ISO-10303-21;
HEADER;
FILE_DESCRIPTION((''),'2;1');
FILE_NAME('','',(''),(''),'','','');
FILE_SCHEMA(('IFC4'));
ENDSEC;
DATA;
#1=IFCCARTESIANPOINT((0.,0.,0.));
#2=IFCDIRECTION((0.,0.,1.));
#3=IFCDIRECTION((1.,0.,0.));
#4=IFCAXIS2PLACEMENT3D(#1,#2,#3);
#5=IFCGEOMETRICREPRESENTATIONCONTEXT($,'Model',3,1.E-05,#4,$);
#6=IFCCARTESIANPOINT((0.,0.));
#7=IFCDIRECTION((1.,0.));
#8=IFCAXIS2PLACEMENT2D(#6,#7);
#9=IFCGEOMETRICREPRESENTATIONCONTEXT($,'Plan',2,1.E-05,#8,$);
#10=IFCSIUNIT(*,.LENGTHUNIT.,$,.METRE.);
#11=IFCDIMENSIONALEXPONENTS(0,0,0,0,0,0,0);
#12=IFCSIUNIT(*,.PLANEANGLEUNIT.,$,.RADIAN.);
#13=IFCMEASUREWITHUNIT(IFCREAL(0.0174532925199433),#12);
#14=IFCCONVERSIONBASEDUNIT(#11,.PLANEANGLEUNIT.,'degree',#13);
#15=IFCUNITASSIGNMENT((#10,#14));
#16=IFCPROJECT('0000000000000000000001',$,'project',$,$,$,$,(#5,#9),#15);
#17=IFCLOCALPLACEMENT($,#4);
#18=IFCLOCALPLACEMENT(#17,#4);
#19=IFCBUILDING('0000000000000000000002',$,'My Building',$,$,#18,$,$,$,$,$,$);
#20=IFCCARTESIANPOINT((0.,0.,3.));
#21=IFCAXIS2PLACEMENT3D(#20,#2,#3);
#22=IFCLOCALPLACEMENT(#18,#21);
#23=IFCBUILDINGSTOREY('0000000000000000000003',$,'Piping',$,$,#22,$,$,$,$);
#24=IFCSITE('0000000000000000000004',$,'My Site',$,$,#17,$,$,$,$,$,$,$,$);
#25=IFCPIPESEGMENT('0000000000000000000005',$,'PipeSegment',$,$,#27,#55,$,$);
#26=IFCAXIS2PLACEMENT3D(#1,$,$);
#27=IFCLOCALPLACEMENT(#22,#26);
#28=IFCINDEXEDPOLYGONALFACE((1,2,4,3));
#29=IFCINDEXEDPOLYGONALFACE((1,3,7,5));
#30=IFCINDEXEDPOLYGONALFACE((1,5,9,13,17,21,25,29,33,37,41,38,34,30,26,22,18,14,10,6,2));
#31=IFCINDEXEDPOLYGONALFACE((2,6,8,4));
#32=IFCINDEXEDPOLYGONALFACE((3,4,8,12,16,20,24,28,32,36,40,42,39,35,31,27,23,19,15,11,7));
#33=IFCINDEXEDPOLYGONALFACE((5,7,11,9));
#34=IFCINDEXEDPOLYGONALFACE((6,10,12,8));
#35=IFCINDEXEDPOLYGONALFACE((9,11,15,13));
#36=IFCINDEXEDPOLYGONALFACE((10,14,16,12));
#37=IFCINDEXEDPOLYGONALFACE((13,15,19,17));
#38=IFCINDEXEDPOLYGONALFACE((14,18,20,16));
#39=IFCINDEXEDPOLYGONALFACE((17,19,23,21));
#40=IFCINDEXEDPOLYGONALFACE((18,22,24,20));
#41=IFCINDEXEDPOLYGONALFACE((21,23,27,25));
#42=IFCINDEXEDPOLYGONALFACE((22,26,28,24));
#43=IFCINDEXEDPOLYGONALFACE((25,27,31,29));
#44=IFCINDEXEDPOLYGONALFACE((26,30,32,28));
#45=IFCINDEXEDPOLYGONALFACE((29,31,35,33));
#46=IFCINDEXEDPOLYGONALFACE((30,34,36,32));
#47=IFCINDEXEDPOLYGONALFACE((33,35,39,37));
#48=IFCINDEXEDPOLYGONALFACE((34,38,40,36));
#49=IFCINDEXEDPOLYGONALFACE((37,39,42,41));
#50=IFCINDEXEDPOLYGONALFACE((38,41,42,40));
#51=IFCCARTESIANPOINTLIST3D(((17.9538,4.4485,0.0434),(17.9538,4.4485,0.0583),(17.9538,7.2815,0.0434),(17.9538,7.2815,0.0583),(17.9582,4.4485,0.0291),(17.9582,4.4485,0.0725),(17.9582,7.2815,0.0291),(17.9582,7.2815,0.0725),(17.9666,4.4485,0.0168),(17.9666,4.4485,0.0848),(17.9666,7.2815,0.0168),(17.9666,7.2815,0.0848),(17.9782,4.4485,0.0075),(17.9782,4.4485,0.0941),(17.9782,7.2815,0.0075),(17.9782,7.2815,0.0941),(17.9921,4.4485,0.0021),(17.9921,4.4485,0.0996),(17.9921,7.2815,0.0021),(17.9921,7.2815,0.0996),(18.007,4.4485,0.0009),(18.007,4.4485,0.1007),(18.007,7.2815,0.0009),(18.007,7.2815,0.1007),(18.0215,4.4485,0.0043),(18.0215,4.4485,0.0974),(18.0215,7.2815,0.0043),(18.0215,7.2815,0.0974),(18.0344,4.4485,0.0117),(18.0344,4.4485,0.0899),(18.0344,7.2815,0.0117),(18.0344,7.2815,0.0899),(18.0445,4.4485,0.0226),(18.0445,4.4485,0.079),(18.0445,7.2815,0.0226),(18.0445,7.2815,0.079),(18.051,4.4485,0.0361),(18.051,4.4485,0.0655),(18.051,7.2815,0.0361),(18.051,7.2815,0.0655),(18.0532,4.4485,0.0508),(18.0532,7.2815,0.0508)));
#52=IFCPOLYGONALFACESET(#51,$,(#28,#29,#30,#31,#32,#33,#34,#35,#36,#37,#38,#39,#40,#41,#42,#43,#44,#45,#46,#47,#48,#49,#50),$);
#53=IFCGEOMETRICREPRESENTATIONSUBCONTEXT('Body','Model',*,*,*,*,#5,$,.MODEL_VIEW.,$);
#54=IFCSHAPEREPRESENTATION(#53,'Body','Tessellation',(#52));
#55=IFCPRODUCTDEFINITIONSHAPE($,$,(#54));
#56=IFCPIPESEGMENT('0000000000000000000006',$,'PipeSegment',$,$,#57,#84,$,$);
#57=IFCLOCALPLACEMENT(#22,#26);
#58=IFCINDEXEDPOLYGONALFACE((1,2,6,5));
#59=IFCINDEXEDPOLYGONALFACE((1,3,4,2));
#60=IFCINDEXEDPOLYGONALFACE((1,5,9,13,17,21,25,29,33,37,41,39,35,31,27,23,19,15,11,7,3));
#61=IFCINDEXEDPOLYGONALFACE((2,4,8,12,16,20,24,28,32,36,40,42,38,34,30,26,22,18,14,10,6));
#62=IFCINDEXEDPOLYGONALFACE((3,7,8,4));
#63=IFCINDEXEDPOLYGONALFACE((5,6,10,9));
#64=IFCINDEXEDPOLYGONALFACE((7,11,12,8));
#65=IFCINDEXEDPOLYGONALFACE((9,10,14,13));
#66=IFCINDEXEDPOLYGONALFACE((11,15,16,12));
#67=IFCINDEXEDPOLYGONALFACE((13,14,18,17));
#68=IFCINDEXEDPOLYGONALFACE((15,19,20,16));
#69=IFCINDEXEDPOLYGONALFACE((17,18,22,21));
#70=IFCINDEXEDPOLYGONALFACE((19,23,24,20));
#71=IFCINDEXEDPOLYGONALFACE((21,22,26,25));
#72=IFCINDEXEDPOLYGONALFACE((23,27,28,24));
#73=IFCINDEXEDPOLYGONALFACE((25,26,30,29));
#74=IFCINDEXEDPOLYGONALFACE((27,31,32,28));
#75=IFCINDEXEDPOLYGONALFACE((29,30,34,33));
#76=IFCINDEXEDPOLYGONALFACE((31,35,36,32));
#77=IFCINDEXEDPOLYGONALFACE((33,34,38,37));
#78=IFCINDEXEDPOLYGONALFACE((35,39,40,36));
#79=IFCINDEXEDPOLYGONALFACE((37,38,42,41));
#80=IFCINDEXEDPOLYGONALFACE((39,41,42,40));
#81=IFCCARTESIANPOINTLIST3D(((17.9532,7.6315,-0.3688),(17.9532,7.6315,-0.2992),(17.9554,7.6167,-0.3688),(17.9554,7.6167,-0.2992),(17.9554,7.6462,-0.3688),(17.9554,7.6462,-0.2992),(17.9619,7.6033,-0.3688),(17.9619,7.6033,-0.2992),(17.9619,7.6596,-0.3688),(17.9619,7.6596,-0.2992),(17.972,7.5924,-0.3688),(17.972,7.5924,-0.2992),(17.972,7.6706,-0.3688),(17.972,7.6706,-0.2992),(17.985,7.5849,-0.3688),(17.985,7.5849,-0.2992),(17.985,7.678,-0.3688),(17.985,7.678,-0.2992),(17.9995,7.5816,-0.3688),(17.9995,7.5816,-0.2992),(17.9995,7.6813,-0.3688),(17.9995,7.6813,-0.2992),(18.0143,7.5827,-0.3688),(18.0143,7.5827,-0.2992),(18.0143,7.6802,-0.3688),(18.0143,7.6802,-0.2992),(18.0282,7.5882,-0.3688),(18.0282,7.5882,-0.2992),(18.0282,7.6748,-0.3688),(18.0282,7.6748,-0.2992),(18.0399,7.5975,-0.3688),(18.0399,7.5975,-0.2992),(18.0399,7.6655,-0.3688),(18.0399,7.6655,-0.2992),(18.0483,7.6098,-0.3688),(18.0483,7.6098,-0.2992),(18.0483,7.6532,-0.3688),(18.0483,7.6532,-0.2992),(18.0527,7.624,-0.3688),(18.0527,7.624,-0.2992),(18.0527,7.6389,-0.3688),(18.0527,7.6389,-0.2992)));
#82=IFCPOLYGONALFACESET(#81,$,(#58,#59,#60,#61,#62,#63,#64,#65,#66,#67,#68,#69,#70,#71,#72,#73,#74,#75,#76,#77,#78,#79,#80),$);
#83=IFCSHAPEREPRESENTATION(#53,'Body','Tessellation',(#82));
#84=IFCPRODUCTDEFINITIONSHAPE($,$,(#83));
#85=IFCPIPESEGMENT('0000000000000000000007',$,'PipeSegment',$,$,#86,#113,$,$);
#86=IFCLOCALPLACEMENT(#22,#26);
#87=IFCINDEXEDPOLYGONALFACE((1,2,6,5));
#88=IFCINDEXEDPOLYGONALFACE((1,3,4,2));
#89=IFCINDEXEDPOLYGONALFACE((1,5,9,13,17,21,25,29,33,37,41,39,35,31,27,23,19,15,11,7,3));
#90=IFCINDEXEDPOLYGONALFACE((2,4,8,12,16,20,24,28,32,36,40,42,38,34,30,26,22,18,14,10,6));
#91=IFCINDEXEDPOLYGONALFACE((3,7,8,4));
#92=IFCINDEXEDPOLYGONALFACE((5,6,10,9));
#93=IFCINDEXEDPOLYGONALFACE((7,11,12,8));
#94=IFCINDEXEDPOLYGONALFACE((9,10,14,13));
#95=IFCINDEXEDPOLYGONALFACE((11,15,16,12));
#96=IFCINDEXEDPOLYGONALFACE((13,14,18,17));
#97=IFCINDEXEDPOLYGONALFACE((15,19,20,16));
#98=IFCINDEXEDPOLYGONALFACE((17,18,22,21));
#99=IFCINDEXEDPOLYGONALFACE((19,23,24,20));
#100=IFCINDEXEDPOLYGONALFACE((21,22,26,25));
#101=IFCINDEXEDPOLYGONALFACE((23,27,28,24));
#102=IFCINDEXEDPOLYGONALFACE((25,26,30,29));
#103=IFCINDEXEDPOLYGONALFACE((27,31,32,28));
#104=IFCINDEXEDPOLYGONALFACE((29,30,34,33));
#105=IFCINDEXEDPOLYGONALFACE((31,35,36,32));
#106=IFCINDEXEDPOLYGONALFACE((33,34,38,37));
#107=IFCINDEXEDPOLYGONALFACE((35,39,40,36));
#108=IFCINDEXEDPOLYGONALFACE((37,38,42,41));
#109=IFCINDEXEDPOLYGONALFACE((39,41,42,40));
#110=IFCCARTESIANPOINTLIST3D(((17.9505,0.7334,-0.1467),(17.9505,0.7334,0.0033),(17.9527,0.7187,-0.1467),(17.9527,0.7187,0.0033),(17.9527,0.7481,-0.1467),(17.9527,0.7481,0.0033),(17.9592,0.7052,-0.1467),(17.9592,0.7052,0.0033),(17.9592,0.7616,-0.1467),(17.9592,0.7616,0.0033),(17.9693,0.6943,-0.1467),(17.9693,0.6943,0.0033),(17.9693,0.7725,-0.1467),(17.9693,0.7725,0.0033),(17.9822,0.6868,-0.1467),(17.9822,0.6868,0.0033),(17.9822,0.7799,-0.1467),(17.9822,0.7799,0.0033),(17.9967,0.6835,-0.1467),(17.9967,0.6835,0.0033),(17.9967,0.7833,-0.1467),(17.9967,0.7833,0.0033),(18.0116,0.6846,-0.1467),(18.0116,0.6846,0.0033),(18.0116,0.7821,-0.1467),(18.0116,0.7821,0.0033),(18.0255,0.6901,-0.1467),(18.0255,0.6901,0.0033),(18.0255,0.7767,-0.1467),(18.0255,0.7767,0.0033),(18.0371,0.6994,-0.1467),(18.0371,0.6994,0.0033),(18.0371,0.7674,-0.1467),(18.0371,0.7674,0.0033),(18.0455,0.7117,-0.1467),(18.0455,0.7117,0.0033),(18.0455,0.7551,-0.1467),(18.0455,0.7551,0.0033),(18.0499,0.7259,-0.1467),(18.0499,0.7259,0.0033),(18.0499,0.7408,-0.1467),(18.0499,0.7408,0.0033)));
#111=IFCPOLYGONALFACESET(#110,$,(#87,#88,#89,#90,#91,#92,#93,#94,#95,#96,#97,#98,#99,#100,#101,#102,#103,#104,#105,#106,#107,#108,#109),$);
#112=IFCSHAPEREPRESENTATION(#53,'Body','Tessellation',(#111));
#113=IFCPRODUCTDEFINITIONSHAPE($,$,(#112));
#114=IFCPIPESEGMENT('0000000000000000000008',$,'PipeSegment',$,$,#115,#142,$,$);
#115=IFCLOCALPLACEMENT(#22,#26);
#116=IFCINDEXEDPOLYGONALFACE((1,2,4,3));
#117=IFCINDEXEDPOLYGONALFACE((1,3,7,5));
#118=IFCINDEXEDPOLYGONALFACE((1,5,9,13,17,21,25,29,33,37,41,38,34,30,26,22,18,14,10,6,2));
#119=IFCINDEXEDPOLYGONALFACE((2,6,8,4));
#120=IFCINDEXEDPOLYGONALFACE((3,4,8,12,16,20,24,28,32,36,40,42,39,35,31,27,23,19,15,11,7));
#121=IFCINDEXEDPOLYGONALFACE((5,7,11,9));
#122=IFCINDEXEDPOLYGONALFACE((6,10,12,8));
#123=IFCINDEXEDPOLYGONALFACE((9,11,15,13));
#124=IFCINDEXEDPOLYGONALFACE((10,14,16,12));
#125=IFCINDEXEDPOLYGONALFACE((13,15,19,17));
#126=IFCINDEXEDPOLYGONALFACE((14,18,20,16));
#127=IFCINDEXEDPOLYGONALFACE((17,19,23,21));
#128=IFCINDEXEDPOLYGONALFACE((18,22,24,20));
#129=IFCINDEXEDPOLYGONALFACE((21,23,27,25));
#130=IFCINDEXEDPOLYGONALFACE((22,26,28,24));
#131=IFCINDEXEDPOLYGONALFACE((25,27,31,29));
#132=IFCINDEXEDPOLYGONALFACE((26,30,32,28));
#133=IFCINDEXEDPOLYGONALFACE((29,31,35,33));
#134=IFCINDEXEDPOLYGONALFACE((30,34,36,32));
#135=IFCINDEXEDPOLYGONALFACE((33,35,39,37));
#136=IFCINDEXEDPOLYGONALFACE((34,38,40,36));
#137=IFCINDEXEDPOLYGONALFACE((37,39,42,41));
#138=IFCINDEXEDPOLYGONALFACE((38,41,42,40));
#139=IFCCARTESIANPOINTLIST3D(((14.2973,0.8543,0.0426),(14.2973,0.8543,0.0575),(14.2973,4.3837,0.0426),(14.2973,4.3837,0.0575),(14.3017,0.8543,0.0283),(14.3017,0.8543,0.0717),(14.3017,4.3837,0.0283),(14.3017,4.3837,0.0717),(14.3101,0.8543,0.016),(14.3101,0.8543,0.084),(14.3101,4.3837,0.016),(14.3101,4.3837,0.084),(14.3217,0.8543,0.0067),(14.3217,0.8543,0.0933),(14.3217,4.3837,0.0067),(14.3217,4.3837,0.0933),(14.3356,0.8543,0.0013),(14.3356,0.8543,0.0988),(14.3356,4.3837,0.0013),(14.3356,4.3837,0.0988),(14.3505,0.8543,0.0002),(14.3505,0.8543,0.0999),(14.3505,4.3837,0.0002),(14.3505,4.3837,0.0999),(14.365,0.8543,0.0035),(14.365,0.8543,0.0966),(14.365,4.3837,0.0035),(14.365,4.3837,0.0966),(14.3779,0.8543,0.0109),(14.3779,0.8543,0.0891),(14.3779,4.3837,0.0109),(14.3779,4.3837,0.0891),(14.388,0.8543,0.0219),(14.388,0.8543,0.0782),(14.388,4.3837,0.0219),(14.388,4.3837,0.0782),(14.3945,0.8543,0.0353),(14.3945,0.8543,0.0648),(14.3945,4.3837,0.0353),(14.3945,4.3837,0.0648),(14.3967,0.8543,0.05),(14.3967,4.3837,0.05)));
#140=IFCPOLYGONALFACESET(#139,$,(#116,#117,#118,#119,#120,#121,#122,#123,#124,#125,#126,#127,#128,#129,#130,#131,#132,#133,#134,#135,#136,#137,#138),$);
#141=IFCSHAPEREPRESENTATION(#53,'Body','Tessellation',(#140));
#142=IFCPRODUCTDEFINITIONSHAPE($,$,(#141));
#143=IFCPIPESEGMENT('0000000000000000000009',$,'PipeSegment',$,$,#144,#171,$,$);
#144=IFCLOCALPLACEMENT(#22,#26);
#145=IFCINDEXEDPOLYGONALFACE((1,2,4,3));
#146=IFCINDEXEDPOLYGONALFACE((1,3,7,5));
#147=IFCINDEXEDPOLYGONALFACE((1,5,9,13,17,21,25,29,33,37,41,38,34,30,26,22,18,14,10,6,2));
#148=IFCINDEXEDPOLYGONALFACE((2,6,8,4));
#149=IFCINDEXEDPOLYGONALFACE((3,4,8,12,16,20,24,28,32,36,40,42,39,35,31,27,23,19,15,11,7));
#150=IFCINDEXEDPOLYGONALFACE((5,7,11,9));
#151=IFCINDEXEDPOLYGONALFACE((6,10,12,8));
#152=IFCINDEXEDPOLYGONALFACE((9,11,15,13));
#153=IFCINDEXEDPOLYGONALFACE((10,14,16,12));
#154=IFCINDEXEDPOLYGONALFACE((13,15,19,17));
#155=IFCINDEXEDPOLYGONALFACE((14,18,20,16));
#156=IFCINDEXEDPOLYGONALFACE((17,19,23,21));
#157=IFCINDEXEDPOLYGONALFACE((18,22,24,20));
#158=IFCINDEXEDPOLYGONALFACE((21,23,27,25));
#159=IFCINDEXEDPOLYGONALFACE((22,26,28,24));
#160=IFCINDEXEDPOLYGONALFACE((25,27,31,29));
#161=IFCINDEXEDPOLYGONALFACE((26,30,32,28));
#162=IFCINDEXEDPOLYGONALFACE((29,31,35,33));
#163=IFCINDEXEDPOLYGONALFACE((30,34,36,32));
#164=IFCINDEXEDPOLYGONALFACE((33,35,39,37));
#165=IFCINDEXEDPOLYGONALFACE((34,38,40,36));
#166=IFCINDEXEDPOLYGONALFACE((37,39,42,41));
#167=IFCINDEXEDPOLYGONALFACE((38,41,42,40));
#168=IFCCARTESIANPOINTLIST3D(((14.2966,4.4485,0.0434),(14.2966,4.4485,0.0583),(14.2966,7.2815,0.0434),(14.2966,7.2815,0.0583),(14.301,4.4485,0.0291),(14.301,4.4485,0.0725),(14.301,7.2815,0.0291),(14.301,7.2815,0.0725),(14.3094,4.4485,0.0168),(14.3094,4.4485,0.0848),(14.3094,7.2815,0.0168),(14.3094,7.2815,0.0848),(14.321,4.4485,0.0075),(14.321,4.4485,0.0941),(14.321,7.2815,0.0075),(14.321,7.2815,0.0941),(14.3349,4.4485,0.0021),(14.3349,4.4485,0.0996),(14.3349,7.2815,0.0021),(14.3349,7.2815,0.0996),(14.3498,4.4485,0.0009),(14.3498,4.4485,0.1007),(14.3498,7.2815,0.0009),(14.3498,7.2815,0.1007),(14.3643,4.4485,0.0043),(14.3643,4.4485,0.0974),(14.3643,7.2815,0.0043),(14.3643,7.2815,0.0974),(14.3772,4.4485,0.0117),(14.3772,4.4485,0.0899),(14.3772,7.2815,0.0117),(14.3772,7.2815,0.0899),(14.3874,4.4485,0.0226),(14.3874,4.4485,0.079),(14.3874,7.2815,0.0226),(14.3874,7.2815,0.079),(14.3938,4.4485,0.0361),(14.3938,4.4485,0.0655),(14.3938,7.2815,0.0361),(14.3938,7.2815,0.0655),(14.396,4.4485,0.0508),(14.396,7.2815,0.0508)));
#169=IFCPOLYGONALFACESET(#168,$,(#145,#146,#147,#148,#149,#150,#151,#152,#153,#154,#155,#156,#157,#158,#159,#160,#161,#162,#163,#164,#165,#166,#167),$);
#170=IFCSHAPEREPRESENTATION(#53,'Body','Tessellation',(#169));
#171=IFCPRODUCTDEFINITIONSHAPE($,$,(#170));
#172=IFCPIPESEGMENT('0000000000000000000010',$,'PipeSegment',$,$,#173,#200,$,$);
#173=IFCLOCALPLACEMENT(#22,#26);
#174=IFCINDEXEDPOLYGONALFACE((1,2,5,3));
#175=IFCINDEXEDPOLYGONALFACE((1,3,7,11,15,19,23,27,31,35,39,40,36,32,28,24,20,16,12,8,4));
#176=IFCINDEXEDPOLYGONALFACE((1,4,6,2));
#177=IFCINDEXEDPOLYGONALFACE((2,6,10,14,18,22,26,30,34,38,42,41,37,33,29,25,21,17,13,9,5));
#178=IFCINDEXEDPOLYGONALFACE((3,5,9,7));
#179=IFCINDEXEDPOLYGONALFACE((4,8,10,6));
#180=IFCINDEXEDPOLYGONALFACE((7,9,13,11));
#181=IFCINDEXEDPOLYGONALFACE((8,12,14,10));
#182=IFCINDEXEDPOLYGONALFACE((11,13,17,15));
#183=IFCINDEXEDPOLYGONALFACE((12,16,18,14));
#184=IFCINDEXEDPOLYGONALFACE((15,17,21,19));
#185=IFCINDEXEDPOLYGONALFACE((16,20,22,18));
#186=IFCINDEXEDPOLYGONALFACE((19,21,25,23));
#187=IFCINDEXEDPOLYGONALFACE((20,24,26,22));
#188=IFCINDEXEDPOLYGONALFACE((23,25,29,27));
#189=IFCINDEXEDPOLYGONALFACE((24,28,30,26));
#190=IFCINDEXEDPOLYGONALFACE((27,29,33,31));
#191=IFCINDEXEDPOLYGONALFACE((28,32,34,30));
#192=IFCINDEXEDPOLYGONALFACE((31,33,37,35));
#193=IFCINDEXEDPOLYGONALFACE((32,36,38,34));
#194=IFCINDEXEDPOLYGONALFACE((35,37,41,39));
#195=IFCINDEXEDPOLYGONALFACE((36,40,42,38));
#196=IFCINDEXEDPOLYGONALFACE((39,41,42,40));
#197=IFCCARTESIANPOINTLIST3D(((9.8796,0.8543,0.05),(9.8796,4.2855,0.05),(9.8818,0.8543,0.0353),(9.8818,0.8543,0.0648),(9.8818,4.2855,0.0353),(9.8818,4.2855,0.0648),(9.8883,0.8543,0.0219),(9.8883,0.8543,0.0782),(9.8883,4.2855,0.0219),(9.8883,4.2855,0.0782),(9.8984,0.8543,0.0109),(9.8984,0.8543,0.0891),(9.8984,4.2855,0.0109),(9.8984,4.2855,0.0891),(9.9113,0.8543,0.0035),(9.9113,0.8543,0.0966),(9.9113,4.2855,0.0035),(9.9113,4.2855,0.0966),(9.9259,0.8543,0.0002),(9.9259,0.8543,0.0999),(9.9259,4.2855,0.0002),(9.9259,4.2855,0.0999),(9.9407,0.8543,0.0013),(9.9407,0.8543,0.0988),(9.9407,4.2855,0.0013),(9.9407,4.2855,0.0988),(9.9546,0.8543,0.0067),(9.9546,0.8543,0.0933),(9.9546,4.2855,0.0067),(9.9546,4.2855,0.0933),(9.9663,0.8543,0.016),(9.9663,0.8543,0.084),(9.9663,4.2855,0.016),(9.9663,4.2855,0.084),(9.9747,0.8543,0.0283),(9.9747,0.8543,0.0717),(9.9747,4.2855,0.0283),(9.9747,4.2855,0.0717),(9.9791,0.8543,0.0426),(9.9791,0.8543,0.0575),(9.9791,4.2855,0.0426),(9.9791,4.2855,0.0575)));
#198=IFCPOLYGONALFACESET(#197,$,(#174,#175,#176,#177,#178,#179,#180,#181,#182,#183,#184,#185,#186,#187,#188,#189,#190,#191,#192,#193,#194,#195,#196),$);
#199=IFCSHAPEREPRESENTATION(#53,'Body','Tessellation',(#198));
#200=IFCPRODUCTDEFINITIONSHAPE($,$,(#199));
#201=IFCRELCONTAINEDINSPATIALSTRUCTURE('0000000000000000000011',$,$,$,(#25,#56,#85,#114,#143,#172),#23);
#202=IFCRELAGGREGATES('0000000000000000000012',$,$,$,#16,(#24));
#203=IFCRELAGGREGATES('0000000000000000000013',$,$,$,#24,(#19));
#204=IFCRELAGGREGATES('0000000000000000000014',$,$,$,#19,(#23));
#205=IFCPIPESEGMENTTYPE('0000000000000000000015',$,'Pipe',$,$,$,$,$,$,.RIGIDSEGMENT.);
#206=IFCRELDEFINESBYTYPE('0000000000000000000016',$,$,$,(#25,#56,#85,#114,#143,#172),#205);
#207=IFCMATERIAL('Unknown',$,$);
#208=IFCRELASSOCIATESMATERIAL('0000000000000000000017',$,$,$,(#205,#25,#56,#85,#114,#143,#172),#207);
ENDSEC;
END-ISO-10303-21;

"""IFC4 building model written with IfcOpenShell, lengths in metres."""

from ifc_helpers import new_model, entity, si_unit, converted_unit, frame, origin_with_axes, origin_2d_with_axis, place, context, subcontext, project, spatial, circle, extrude, material, material_profile, profile_set, profile_usage, type_object, element, save


model = new_model("IFC4")

# Units and contexts
model_context = context("Model", 3, precision=1e-05, world=origin_with_axes())
plan_context = context("Plan", 2, precision=1e-05, world=origin_2d_with_axis())
body_context = subcontext(model_context, "Body", "Model", "MODEL_VIEW")
ifc_project = project(units=[si_unit("LENGTHUNIT", "METRE"), converted_unit("PLANEANGLEUNIT", "degree", entity("IfcReal", 0.0174532925199433), si_unit("PLANEANGLEUNIT", "RADIAN"), dimensions=[0, 0, 0, 0, 0, 0, 0])], contexts=[model_context, plan_context])

# Site, building, storey
site_placement = place(None, origin_with_axes())
site = spatial("IfcSite", under=ifc_project, at=site_placement, Name="My Site")
building_placement = place(site_placement, origin_with_axes())
building = spatial("IfcBuilding", under=site, at=building_placement, Name="My Building")
storey_placement = place(building_placement, frame((0.0, 0.0, 3.0), z_axis=(0.0, 0.0, 1.0), x_axis=(1.0, 0.0, 0.0)))
storey = spatial("IfcBuildingStorey", under=building, at=storey_placement, Name="Piping")

# Pipe segments
ifc_material = material(Name="Unknown")
ifc_material_profile_1 = material_profile(ifc_material, circle(Radius=0.05))
ifc_profile_set_1 = profile_set([ifc_material_profile_1])
pipe_segment_type = type_object("IfcPipeSegmentType", Name="Pipe", PredefinedType="RIGIDSEGMENT", material=ifc_profile_set_1)
ifc_profile_usage_1 = profile_usage(ifc_profile_set_1, cardinal=5)
pipe_segment_1_placement = place(storey_placement, frame((18.0032, 4.4485, 0.0508), z_axis=(0.0, 1.0, 0.0), x_axis=(1.0, 0.0, 0.0)))
element("IfcPipeSegment", 1, at=pipe_segment_1_placement, inside=storey, type_object=pipe_segment_type, material=ifc_profile_usage_1, Name="PipeSegment", context=body_context, shape_type="SweptSolid", body=[
    extrude(circle(Radius=0.05), origin_with_axes(), (0.0, 0.0, 1.0), 2.833),
])
ifc_profile_usage_2 = profile_usage(ifc_profile_set_1, cardinal=16)
pipe_segment_2_placement = place(storey_placement, frame((18.0032, 7.6315, -0.2992), z_axis=(0.0, 0.0, -1.0), x_axis=(-1.0, 0.0, 0.0)))
element("IfcPipeSegment", 2, at=pipe_segment_2_placement, inside=storey, type_object=pipe_segment_type, material=ifc_profile_usage_2, Name="PipeSegment", context=body_context, shape_type="SweptSolid", body=[
    extrude(circle(Radius=0.05), origin_with_axes(), (0.0, 0.0, 1.0), 0.0696),
])
ifc_profile_usage_3 = profile_usage(ifc_profile_set_1, cardinal=16)
pipe_segment_3_placement = place(storey_placement, frame((18.0005, 0.7334, 0.0033), z_axis=(0.0, 0.0, -1.0), x_axis=(-1.0, 0.0, 0.0)))
element("IfcPipeSegment", 3, at=pipe_segment_3_placement, inside=storey, type_object=pipe_segment_type, material=ifc_profile_usage_3, Name="PipeSegment", context=body_context, shape_type="SweptSolid", body=[
    extrude(circle(Radius=0.05), origin_with_axes(), (0.0, 0.0, 1.0), 0.15),
])
ifc_profile_usage_4 = profile_usage(ifc_profile_set_1, cardinal=5)
pipe_segment_4_placement = place(storey_placement, frame((14.3467, 4.3837, 0.05), z_axis=(0.0, -1.0, 0.0), x_axis=(1.0, 0.0, 0.0)))
element("IfcPipeSegment", 4, at=pipe_segment_4_placement, inside=storey, type_object=pipe_segment_type, material=ifc_profile_usage_4, Name="PipeSegment", context=body_context, shape_type="SweptSolid", body=[
    extrude(circle(Radius=0.05), origin_with_axes(), (0.0, 0.0, 1.0), 3.5295),
])
ifc_profile_usage_5 = profile_usage(ifc_profile_set_1, cardinal=5)
pipe_segment_5_placement = place(storey_placement, frame((14.346, 4.4485, 0.0508), z_axis=(0.0, 1.0, 0.0), x_axis=(1.0, 0.0, 0.0)))
element("IfcPipeSegment", 5, at=pipe_segment_5_placement, inside=storey, type_object=pipe_segment_type, material=ifc_profile_usage_5, Name="PipeSegment", context=body_context, shape_type="SweptSolid", body=[
    extrude(circle(Radius=0.05), origin_with_axes(), (0.0, 0.0, 1.0), 2.833),
])
ifc_profile_usage_6 = profile_usage(ifc_profile_set_1, cardinal=5)
pipe_segment_6_placement = place(storey_placement, frame((9.9296, 0.8543, 0.05), z_axis=(0.0, 1.0, 0.0), x_axis=(-1.0, 0.0, 0.0)))
element("IfcPipeSegment", 6, at=pipe_segment_6_placement, inside=storey, type_object=pipe_segment_type, material=ifc_profile_usage_6, Name="PipeSegment", context=body_context, shape_type="SweptSolid", body=[
    extrude(circle(Radius=0.05), origin_with_axes(), (0.0, 0.0, 1.0), 3.4313),
])

save(model, "model.ifc")
